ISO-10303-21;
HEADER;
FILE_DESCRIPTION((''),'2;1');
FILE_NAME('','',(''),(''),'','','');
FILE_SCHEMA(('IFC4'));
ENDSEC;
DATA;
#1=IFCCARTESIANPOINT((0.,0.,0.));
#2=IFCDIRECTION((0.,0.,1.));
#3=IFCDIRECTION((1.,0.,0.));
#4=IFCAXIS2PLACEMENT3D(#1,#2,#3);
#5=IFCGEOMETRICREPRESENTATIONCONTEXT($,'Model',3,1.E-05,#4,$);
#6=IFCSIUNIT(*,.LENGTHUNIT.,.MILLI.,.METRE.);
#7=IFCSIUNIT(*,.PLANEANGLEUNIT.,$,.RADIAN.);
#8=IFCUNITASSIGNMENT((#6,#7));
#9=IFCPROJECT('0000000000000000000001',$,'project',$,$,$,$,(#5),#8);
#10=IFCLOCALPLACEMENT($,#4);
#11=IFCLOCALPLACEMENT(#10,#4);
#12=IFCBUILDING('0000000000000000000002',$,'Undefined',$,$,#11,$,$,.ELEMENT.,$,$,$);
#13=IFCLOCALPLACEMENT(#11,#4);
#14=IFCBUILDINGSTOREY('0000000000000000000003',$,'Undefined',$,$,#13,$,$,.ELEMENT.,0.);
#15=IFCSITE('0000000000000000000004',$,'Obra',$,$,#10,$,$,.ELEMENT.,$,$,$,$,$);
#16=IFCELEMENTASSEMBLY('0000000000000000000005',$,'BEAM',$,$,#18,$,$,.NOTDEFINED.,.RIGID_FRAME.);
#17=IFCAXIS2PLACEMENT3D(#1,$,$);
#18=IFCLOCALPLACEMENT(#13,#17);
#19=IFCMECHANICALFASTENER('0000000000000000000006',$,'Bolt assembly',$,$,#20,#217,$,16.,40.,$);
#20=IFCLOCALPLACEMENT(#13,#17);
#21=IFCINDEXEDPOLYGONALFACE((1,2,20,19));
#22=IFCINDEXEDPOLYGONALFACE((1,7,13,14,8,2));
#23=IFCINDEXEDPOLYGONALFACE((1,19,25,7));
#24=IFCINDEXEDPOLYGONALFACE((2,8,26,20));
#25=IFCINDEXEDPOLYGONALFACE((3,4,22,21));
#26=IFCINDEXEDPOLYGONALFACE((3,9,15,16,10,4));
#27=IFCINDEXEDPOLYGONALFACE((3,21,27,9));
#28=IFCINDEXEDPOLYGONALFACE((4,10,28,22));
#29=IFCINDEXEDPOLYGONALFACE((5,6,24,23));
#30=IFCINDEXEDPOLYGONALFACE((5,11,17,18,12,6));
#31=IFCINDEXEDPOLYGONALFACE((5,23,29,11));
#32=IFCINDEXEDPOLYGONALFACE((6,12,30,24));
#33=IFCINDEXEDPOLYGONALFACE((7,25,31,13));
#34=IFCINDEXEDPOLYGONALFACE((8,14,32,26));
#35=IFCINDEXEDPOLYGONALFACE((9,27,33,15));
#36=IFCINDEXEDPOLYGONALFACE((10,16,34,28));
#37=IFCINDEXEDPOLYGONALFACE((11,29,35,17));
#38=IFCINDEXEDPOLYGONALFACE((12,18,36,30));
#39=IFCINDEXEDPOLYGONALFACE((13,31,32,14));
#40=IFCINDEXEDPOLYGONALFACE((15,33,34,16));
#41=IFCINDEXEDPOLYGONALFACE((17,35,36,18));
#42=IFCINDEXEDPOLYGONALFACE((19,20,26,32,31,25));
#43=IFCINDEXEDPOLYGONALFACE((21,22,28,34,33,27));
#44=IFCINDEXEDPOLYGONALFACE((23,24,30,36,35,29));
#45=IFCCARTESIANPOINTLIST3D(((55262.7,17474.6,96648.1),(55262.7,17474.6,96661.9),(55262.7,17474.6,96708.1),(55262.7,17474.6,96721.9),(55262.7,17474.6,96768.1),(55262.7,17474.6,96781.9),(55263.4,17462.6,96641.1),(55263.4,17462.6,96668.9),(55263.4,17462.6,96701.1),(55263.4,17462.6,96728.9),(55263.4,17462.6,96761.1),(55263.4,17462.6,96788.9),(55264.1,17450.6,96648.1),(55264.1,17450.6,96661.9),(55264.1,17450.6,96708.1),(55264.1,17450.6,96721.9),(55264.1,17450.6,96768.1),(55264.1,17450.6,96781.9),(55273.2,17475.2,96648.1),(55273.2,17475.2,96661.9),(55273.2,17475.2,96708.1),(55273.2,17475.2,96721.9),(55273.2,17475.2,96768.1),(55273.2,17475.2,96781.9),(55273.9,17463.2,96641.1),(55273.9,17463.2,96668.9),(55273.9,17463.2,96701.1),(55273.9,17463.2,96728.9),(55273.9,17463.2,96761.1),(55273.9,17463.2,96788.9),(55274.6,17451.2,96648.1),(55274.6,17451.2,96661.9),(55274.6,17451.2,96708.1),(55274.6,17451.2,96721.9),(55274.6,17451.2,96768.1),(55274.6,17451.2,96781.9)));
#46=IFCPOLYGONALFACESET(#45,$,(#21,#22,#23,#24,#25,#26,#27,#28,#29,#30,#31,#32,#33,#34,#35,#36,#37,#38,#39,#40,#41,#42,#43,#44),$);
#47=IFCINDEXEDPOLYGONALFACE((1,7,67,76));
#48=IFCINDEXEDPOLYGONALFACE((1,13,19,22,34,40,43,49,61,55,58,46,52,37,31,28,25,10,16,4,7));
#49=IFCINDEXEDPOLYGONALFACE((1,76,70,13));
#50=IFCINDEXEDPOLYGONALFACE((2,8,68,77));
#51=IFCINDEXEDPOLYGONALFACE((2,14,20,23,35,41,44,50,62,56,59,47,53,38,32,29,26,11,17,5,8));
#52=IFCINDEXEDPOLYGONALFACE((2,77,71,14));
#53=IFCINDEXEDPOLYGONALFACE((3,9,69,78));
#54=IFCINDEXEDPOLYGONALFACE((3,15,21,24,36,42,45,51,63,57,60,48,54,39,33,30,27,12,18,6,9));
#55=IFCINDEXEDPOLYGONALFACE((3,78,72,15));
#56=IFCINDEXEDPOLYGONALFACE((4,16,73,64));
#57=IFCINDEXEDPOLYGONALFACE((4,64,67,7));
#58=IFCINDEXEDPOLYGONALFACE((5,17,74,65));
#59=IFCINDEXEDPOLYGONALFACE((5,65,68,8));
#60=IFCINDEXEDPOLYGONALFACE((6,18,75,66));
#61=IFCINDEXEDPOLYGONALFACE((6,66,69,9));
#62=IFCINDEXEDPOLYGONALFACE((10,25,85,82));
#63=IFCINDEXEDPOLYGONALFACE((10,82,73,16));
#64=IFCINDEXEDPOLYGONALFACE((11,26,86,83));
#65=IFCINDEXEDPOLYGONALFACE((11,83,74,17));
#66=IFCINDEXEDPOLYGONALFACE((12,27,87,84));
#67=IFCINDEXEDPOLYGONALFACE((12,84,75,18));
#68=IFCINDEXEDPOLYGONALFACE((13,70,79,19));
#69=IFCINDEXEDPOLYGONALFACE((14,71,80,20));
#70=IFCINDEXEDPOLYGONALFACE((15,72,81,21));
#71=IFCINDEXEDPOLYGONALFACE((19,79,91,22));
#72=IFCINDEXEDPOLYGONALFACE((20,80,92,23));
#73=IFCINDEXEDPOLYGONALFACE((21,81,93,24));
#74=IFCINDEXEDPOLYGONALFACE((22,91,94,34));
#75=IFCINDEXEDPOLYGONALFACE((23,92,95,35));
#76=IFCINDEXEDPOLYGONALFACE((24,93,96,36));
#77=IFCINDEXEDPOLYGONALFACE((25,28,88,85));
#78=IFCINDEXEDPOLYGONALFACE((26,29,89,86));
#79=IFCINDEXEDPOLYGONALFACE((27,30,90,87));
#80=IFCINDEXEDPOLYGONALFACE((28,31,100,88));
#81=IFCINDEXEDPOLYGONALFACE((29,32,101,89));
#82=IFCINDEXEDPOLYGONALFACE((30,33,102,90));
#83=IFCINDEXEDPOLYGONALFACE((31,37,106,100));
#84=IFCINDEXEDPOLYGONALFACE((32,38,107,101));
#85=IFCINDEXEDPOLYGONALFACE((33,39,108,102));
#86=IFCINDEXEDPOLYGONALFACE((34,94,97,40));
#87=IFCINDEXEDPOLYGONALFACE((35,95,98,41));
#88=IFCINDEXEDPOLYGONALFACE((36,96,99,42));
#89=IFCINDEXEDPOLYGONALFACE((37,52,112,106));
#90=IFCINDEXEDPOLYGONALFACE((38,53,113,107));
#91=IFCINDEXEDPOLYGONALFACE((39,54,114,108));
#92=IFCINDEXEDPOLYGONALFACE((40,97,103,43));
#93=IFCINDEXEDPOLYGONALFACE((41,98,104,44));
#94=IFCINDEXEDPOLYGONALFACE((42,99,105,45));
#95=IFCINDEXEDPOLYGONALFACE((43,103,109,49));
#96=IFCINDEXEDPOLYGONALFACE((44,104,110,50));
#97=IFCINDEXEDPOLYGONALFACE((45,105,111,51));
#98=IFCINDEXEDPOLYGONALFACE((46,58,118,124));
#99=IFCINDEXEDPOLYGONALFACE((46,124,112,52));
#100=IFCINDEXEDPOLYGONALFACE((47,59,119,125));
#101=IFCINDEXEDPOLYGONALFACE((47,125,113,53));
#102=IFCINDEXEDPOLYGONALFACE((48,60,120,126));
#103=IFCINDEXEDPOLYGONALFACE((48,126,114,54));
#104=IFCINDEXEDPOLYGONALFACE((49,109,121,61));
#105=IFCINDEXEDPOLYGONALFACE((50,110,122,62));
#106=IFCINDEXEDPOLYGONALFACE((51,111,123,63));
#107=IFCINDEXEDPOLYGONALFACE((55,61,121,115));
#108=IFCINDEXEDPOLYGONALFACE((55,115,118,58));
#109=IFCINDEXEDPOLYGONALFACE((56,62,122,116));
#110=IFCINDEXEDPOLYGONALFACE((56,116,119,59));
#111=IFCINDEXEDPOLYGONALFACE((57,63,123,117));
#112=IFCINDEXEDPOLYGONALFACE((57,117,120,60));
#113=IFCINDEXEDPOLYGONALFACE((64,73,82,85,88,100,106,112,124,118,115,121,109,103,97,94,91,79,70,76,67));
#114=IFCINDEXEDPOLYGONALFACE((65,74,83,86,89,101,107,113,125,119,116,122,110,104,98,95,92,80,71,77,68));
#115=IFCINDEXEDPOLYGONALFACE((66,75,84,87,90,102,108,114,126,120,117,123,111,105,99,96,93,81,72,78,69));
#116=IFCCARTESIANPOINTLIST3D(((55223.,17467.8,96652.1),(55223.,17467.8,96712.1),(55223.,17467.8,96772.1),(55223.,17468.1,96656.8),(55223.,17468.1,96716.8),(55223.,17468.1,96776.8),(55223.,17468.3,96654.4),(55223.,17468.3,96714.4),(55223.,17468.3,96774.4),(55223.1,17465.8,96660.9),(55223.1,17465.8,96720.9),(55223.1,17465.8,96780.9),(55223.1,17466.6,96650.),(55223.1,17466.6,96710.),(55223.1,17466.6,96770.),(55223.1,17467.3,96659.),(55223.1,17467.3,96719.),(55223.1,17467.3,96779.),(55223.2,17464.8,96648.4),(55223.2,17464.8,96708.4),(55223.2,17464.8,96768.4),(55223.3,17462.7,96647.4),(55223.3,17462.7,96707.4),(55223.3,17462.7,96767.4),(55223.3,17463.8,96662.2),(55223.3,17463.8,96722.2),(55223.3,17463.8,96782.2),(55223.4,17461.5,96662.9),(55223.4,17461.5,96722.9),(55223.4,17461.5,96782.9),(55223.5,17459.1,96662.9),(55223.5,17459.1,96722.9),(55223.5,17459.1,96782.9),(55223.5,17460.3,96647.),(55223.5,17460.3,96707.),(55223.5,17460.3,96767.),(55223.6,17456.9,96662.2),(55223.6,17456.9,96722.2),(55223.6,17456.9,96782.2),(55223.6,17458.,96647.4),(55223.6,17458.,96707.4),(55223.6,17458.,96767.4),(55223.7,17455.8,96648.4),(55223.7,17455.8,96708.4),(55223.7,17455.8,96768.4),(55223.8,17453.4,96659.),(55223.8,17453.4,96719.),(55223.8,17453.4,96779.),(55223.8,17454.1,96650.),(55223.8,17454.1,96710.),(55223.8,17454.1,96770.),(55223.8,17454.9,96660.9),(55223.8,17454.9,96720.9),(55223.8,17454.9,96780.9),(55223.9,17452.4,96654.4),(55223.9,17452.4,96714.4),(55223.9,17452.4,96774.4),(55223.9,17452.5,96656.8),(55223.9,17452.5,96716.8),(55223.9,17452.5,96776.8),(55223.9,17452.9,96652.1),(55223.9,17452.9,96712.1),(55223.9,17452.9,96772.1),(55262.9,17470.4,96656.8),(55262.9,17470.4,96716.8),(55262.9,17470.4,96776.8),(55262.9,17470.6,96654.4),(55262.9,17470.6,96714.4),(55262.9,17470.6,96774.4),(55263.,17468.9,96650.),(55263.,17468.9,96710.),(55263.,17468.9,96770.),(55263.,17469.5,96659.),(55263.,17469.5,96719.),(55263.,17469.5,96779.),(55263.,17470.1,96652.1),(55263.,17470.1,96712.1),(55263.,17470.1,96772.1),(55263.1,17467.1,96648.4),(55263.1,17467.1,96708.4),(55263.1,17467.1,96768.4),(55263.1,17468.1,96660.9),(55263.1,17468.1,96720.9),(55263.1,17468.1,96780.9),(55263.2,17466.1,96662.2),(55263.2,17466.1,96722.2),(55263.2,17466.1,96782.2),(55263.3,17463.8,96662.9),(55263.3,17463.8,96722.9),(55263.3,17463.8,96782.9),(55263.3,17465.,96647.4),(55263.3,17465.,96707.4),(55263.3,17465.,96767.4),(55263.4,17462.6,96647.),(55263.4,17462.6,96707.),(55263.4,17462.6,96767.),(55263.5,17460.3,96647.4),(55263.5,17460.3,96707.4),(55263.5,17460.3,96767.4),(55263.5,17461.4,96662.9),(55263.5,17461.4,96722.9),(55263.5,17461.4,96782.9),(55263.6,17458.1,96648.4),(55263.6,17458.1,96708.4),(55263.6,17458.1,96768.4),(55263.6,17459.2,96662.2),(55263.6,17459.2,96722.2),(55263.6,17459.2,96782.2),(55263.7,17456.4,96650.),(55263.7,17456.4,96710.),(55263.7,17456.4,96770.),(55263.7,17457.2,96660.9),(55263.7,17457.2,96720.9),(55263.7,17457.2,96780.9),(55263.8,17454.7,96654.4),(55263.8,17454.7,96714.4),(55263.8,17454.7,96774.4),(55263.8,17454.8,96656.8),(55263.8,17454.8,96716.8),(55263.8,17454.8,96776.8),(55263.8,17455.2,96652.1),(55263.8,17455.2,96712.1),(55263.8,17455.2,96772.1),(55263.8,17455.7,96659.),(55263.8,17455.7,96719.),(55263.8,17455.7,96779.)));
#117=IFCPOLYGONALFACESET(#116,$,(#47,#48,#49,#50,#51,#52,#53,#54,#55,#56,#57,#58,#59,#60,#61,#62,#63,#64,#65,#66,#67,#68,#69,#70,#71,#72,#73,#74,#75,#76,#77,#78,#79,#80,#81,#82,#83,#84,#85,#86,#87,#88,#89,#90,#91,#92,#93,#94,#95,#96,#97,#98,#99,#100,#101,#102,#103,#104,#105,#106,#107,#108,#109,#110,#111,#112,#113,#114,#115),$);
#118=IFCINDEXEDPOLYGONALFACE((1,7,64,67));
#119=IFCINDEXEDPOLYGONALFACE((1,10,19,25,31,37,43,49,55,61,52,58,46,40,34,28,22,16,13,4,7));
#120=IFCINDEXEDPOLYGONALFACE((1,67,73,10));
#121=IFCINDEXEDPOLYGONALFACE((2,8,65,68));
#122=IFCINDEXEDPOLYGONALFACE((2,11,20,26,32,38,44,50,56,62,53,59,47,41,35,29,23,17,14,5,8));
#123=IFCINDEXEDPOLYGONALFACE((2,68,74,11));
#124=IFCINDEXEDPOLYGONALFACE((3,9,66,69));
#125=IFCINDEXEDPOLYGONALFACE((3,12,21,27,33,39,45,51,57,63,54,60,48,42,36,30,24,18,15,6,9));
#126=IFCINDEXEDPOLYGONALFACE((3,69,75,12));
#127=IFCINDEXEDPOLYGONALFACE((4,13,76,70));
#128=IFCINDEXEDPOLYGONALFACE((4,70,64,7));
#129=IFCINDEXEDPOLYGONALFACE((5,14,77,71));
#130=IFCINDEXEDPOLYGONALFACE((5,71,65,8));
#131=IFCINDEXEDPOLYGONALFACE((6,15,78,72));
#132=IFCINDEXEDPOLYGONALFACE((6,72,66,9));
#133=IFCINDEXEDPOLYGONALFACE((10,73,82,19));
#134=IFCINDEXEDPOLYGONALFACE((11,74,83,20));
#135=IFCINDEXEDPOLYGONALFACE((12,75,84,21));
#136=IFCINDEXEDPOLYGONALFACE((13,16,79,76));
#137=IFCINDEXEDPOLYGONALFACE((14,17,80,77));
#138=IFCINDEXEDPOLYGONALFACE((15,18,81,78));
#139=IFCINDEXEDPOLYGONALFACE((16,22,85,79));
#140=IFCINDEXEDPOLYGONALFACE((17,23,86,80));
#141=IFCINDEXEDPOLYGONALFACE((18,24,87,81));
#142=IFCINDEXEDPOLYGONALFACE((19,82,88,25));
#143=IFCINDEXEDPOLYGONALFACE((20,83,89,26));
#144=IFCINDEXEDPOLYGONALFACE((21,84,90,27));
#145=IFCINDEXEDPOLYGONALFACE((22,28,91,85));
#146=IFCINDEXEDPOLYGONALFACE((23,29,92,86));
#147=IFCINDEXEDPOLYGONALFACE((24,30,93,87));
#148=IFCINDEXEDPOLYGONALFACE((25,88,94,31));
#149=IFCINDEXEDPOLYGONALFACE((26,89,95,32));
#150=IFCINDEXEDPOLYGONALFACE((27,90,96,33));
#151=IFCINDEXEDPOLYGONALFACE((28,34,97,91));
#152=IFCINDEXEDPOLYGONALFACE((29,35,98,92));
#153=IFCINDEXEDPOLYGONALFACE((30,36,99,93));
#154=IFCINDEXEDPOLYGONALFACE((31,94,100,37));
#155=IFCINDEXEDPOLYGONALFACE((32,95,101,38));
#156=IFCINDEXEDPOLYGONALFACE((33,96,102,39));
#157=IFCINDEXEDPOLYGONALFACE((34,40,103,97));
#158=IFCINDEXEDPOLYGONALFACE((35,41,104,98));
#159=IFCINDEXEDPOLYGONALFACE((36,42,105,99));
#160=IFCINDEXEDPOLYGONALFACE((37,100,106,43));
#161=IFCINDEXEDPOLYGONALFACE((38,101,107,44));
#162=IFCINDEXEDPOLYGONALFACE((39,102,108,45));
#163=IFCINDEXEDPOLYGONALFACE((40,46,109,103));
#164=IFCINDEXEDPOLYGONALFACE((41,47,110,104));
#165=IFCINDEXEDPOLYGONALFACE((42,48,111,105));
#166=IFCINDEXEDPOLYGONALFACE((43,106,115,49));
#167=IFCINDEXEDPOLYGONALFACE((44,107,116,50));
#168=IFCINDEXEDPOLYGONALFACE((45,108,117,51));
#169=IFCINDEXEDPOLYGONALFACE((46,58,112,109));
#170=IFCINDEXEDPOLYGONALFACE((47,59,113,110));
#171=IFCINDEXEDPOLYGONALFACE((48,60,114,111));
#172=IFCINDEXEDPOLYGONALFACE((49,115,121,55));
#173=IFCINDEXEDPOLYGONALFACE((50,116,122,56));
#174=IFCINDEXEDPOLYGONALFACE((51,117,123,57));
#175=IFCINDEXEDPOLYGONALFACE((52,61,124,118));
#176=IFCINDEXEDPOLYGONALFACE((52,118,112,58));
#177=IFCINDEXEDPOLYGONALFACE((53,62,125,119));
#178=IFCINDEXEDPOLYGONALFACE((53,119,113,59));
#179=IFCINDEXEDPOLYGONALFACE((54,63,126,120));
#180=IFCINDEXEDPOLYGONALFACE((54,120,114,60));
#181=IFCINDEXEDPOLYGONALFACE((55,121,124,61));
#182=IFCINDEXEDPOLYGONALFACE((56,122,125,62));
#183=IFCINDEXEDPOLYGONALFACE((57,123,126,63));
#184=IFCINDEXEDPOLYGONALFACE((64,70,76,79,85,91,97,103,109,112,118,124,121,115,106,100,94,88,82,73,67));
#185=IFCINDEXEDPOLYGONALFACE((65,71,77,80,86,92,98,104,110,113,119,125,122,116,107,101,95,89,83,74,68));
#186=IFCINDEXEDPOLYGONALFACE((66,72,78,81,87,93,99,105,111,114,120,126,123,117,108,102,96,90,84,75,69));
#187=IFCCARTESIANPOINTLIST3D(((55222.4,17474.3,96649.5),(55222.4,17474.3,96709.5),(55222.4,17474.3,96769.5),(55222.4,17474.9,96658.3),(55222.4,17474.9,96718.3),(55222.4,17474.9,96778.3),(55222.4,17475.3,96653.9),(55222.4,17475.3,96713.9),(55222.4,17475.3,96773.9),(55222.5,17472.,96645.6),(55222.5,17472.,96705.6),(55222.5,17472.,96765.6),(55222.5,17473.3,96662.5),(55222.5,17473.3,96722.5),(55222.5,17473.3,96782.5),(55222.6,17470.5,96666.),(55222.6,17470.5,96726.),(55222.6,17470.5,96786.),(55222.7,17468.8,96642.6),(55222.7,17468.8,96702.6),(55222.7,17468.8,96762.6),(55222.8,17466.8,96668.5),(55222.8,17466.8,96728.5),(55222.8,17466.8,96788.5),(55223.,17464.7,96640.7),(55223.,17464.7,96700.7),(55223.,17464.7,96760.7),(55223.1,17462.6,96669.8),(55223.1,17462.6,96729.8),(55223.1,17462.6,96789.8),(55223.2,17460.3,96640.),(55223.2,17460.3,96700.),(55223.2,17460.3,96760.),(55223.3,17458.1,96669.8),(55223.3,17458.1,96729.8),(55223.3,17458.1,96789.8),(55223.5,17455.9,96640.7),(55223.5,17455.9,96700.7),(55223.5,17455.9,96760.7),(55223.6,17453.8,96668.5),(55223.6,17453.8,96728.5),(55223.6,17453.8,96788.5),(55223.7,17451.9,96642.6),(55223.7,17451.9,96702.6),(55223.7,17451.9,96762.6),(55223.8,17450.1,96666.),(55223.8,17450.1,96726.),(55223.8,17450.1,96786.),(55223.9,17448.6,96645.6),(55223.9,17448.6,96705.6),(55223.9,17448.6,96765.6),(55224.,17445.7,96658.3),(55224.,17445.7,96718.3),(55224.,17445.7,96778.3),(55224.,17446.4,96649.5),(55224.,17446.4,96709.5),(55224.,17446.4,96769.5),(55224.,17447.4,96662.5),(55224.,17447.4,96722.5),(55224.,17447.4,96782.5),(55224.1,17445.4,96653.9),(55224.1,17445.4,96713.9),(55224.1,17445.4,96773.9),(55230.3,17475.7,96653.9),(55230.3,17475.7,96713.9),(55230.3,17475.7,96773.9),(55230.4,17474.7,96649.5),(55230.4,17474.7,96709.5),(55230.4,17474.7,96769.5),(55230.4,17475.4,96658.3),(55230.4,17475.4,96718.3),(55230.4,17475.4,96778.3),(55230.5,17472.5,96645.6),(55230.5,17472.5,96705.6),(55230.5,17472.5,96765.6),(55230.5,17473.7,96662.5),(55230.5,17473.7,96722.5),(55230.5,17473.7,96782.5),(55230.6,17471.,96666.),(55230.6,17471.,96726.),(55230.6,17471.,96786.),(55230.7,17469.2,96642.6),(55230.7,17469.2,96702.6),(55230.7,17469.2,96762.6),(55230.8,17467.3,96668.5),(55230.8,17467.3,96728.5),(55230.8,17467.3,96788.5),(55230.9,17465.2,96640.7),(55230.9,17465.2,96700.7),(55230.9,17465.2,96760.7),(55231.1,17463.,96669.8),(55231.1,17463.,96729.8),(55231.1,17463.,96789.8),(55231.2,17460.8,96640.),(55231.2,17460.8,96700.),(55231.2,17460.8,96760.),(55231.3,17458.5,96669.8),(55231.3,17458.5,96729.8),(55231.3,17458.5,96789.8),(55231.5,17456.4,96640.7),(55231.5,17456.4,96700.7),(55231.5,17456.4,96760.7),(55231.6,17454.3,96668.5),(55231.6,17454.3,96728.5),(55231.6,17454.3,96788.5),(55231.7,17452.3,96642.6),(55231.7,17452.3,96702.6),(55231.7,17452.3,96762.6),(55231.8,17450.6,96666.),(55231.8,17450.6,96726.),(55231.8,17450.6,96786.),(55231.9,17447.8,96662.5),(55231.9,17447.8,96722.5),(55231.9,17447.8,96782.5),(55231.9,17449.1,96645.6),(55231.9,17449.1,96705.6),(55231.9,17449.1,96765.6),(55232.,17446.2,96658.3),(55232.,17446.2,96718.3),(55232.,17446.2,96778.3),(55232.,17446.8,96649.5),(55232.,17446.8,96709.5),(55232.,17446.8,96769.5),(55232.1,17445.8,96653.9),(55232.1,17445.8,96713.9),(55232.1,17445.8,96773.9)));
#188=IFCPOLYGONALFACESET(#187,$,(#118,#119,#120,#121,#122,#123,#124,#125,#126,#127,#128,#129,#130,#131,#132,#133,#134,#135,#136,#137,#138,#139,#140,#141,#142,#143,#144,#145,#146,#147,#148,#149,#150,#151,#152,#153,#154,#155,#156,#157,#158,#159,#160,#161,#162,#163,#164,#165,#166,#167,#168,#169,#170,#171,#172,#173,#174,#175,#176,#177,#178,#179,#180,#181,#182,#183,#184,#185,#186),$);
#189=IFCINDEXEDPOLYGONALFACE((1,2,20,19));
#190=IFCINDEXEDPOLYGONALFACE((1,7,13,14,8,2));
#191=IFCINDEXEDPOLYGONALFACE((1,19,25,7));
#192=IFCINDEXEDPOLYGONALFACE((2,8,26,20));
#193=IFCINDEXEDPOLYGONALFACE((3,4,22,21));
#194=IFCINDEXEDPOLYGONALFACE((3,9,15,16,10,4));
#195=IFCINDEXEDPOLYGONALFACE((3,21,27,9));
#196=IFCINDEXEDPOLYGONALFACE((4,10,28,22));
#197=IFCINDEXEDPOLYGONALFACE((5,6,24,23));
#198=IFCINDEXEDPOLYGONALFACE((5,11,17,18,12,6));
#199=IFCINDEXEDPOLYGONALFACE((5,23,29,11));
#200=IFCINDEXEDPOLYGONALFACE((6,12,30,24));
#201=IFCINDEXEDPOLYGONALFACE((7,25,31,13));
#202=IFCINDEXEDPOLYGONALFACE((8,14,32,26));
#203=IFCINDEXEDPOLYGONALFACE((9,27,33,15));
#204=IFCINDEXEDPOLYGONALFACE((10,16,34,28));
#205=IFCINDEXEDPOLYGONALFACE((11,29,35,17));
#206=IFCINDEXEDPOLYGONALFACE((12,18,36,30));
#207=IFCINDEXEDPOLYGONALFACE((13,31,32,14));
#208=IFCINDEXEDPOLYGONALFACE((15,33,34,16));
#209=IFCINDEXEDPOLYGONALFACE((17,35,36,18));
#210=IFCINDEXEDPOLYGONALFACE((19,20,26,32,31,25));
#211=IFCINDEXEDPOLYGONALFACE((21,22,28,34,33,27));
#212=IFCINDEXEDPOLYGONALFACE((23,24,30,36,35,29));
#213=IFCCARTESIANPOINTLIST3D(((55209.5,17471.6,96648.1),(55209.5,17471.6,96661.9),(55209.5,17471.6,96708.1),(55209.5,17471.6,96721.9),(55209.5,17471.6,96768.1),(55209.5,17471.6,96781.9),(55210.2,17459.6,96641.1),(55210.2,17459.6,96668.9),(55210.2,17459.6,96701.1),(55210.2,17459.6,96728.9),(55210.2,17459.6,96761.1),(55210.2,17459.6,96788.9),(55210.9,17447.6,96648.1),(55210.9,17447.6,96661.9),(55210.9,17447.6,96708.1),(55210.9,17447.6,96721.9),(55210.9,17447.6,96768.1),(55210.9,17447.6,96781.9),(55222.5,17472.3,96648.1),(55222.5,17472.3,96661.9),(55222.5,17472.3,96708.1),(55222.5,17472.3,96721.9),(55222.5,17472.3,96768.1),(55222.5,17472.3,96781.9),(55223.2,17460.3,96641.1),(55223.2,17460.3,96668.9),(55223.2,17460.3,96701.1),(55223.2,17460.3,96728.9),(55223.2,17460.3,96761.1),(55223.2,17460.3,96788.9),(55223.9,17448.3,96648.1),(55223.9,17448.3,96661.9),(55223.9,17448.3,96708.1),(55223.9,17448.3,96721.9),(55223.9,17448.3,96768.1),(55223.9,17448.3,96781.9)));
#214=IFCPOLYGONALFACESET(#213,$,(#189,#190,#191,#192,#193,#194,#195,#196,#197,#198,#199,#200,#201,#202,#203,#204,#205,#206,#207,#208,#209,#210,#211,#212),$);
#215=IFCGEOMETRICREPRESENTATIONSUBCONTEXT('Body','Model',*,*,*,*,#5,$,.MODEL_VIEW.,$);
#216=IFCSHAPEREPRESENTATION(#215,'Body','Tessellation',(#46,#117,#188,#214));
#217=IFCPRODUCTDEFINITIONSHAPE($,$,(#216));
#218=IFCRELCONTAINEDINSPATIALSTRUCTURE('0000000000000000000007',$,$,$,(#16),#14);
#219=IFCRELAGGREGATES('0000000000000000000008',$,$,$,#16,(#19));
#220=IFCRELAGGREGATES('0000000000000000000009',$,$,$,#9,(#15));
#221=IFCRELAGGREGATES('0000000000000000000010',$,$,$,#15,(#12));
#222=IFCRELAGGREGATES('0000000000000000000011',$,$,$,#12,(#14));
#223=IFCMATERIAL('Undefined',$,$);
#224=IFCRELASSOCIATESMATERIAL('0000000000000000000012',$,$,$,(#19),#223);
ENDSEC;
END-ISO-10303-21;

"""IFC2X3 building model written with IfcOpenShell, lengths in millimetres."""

from ifc_helpers import new_model, si_unit, frame, origin_with_axes, origin_2d_with_axis, place, context, subcontext, project, spatial, polyline, circle, outline, extrude, source, transform, mapped, material, element, aggregate, save


model = new_model("IFC2X3")

# Units and contexts
model_context = context("Model", 3, precision=1e-05, world=origin_with_axes())
body_context = subcontext(model_context, "Body", "Model", "MODEL_VIEW")
ifc_project = project(units=[si_unit("LENGTHUNIT", "METRE", prefix="MILLI"), si_unit("PLANEANGLEUNIT", "RADIAN")], contexts=[model_context])

# Site, building, storey
site_placement = place(None, origin_with_axes())
site = spatial("IfcSite", under=ifc_project, at=site_placement, Name="Obra", CompositionType="ELEMENT")
building_placement = place(site_placement, origin_with_axes())
building = spatial("IfcBuilding", under=site, at=building_placement, Name="Undefined", CompositionType="ELEMENT")
storey_placement = place(building_placement, origin_with_axes())
storey = spatial("IfcBuildingStorey", under=building, at=storey_placement, Name="Undefined", CompositionType="ELEMENT", Elevation=0.0)

# Shared definitions
ifc_material_1 = material(Name="Undefined")

# Element assembly, mechanical fastener
shared_shape_1 = source(origin_with_axes(), body_context, "Body", "SweptSolid", [
    extrude(outline(polyline([(13.9, 0.0), (6.9, 12.0), (-6.9, 12.0), (-13.9, 0.0), (-6.9, -12.0), (6.9, -12.0), (13.9, 0.0)])), frame((0.0, -45.9, 0.0), z_axis=(0.0, 1.0, 0.0), x_axis=(1.0, 0.0, 0.0)), (0.0, 0.0, 1.0), 10.6),
    extrude(circle(Radius=8.0, at=origin_2d_with_axis()), frame((0.0, -35.3, 0.0), z_axis=(0.0, 1.0, 0.0), x_axis=(1.0, 0.0, 0.0)), (0.0, 0.0, 1.0), 40.0),
    extrude(circle(Radius=15.0, at=origin_2d_with_axis()), frame((0.0, -3.1, 0.0), z_axis=(0.0, 1.0, 0.0), x_axis=(1.0, 0.0, 0.0)), (0.0, 0.0, 1.0), 8.0),
    extrude(outline(polyline([(13.9, 0.0), (6.9, 12.0), (-6.9, 12.0), (-13.9, 0.0), (-6.9, -12.0), (6.9, -12.0), (13.9, 0.0)])), frame((0.0, 4.9, 0.0), z_axis=(0.0, 1.0, 0.0), x_axis=(1.0, 0.0, 0.0)), (0.0, 0.0, 1.0), 13.0),
])
assembly_1_placement = place(storey_placement, origin_with_axes())
assembly_1 = element("IfcElementAssembly", 1, at=assembly_1_placement, inside=storey, Name="BEAM", AssemblyPlace="NOTDEFINED", PredefinedType="RIGID_FRAME")
mechanical_fastener_1_placement = place(assembly_1_placement, frame((55231.0, 17410.7, 96835.0), z_axis=(-0.057107, 0.998368, 0.0), x_axis=(0.0, 0.0, -1.0)))
mechanical_fastener_1 = element("IfcMechanicalFastener", 2, at=mechanical_fastener_1_placement, material=ifc_material_1, Name="Bolt assembly", NominalDiameter=16.0, NominalLength=40.0, context=body_context, shape_type="MappedRepresentation", body=[
    mapped(shared_shape_1, transform((60.0, 0.0, 50.0))),
    mapped(shared_shape_1, transform((120.0, 0.0, 50.0))),
    mapped(shared_shape_1, transform((180.0, 0.0, 50.0))),
])
aggregate(assembly_1, [mechanical_fastener_1])

save(model, "model.ifc")
